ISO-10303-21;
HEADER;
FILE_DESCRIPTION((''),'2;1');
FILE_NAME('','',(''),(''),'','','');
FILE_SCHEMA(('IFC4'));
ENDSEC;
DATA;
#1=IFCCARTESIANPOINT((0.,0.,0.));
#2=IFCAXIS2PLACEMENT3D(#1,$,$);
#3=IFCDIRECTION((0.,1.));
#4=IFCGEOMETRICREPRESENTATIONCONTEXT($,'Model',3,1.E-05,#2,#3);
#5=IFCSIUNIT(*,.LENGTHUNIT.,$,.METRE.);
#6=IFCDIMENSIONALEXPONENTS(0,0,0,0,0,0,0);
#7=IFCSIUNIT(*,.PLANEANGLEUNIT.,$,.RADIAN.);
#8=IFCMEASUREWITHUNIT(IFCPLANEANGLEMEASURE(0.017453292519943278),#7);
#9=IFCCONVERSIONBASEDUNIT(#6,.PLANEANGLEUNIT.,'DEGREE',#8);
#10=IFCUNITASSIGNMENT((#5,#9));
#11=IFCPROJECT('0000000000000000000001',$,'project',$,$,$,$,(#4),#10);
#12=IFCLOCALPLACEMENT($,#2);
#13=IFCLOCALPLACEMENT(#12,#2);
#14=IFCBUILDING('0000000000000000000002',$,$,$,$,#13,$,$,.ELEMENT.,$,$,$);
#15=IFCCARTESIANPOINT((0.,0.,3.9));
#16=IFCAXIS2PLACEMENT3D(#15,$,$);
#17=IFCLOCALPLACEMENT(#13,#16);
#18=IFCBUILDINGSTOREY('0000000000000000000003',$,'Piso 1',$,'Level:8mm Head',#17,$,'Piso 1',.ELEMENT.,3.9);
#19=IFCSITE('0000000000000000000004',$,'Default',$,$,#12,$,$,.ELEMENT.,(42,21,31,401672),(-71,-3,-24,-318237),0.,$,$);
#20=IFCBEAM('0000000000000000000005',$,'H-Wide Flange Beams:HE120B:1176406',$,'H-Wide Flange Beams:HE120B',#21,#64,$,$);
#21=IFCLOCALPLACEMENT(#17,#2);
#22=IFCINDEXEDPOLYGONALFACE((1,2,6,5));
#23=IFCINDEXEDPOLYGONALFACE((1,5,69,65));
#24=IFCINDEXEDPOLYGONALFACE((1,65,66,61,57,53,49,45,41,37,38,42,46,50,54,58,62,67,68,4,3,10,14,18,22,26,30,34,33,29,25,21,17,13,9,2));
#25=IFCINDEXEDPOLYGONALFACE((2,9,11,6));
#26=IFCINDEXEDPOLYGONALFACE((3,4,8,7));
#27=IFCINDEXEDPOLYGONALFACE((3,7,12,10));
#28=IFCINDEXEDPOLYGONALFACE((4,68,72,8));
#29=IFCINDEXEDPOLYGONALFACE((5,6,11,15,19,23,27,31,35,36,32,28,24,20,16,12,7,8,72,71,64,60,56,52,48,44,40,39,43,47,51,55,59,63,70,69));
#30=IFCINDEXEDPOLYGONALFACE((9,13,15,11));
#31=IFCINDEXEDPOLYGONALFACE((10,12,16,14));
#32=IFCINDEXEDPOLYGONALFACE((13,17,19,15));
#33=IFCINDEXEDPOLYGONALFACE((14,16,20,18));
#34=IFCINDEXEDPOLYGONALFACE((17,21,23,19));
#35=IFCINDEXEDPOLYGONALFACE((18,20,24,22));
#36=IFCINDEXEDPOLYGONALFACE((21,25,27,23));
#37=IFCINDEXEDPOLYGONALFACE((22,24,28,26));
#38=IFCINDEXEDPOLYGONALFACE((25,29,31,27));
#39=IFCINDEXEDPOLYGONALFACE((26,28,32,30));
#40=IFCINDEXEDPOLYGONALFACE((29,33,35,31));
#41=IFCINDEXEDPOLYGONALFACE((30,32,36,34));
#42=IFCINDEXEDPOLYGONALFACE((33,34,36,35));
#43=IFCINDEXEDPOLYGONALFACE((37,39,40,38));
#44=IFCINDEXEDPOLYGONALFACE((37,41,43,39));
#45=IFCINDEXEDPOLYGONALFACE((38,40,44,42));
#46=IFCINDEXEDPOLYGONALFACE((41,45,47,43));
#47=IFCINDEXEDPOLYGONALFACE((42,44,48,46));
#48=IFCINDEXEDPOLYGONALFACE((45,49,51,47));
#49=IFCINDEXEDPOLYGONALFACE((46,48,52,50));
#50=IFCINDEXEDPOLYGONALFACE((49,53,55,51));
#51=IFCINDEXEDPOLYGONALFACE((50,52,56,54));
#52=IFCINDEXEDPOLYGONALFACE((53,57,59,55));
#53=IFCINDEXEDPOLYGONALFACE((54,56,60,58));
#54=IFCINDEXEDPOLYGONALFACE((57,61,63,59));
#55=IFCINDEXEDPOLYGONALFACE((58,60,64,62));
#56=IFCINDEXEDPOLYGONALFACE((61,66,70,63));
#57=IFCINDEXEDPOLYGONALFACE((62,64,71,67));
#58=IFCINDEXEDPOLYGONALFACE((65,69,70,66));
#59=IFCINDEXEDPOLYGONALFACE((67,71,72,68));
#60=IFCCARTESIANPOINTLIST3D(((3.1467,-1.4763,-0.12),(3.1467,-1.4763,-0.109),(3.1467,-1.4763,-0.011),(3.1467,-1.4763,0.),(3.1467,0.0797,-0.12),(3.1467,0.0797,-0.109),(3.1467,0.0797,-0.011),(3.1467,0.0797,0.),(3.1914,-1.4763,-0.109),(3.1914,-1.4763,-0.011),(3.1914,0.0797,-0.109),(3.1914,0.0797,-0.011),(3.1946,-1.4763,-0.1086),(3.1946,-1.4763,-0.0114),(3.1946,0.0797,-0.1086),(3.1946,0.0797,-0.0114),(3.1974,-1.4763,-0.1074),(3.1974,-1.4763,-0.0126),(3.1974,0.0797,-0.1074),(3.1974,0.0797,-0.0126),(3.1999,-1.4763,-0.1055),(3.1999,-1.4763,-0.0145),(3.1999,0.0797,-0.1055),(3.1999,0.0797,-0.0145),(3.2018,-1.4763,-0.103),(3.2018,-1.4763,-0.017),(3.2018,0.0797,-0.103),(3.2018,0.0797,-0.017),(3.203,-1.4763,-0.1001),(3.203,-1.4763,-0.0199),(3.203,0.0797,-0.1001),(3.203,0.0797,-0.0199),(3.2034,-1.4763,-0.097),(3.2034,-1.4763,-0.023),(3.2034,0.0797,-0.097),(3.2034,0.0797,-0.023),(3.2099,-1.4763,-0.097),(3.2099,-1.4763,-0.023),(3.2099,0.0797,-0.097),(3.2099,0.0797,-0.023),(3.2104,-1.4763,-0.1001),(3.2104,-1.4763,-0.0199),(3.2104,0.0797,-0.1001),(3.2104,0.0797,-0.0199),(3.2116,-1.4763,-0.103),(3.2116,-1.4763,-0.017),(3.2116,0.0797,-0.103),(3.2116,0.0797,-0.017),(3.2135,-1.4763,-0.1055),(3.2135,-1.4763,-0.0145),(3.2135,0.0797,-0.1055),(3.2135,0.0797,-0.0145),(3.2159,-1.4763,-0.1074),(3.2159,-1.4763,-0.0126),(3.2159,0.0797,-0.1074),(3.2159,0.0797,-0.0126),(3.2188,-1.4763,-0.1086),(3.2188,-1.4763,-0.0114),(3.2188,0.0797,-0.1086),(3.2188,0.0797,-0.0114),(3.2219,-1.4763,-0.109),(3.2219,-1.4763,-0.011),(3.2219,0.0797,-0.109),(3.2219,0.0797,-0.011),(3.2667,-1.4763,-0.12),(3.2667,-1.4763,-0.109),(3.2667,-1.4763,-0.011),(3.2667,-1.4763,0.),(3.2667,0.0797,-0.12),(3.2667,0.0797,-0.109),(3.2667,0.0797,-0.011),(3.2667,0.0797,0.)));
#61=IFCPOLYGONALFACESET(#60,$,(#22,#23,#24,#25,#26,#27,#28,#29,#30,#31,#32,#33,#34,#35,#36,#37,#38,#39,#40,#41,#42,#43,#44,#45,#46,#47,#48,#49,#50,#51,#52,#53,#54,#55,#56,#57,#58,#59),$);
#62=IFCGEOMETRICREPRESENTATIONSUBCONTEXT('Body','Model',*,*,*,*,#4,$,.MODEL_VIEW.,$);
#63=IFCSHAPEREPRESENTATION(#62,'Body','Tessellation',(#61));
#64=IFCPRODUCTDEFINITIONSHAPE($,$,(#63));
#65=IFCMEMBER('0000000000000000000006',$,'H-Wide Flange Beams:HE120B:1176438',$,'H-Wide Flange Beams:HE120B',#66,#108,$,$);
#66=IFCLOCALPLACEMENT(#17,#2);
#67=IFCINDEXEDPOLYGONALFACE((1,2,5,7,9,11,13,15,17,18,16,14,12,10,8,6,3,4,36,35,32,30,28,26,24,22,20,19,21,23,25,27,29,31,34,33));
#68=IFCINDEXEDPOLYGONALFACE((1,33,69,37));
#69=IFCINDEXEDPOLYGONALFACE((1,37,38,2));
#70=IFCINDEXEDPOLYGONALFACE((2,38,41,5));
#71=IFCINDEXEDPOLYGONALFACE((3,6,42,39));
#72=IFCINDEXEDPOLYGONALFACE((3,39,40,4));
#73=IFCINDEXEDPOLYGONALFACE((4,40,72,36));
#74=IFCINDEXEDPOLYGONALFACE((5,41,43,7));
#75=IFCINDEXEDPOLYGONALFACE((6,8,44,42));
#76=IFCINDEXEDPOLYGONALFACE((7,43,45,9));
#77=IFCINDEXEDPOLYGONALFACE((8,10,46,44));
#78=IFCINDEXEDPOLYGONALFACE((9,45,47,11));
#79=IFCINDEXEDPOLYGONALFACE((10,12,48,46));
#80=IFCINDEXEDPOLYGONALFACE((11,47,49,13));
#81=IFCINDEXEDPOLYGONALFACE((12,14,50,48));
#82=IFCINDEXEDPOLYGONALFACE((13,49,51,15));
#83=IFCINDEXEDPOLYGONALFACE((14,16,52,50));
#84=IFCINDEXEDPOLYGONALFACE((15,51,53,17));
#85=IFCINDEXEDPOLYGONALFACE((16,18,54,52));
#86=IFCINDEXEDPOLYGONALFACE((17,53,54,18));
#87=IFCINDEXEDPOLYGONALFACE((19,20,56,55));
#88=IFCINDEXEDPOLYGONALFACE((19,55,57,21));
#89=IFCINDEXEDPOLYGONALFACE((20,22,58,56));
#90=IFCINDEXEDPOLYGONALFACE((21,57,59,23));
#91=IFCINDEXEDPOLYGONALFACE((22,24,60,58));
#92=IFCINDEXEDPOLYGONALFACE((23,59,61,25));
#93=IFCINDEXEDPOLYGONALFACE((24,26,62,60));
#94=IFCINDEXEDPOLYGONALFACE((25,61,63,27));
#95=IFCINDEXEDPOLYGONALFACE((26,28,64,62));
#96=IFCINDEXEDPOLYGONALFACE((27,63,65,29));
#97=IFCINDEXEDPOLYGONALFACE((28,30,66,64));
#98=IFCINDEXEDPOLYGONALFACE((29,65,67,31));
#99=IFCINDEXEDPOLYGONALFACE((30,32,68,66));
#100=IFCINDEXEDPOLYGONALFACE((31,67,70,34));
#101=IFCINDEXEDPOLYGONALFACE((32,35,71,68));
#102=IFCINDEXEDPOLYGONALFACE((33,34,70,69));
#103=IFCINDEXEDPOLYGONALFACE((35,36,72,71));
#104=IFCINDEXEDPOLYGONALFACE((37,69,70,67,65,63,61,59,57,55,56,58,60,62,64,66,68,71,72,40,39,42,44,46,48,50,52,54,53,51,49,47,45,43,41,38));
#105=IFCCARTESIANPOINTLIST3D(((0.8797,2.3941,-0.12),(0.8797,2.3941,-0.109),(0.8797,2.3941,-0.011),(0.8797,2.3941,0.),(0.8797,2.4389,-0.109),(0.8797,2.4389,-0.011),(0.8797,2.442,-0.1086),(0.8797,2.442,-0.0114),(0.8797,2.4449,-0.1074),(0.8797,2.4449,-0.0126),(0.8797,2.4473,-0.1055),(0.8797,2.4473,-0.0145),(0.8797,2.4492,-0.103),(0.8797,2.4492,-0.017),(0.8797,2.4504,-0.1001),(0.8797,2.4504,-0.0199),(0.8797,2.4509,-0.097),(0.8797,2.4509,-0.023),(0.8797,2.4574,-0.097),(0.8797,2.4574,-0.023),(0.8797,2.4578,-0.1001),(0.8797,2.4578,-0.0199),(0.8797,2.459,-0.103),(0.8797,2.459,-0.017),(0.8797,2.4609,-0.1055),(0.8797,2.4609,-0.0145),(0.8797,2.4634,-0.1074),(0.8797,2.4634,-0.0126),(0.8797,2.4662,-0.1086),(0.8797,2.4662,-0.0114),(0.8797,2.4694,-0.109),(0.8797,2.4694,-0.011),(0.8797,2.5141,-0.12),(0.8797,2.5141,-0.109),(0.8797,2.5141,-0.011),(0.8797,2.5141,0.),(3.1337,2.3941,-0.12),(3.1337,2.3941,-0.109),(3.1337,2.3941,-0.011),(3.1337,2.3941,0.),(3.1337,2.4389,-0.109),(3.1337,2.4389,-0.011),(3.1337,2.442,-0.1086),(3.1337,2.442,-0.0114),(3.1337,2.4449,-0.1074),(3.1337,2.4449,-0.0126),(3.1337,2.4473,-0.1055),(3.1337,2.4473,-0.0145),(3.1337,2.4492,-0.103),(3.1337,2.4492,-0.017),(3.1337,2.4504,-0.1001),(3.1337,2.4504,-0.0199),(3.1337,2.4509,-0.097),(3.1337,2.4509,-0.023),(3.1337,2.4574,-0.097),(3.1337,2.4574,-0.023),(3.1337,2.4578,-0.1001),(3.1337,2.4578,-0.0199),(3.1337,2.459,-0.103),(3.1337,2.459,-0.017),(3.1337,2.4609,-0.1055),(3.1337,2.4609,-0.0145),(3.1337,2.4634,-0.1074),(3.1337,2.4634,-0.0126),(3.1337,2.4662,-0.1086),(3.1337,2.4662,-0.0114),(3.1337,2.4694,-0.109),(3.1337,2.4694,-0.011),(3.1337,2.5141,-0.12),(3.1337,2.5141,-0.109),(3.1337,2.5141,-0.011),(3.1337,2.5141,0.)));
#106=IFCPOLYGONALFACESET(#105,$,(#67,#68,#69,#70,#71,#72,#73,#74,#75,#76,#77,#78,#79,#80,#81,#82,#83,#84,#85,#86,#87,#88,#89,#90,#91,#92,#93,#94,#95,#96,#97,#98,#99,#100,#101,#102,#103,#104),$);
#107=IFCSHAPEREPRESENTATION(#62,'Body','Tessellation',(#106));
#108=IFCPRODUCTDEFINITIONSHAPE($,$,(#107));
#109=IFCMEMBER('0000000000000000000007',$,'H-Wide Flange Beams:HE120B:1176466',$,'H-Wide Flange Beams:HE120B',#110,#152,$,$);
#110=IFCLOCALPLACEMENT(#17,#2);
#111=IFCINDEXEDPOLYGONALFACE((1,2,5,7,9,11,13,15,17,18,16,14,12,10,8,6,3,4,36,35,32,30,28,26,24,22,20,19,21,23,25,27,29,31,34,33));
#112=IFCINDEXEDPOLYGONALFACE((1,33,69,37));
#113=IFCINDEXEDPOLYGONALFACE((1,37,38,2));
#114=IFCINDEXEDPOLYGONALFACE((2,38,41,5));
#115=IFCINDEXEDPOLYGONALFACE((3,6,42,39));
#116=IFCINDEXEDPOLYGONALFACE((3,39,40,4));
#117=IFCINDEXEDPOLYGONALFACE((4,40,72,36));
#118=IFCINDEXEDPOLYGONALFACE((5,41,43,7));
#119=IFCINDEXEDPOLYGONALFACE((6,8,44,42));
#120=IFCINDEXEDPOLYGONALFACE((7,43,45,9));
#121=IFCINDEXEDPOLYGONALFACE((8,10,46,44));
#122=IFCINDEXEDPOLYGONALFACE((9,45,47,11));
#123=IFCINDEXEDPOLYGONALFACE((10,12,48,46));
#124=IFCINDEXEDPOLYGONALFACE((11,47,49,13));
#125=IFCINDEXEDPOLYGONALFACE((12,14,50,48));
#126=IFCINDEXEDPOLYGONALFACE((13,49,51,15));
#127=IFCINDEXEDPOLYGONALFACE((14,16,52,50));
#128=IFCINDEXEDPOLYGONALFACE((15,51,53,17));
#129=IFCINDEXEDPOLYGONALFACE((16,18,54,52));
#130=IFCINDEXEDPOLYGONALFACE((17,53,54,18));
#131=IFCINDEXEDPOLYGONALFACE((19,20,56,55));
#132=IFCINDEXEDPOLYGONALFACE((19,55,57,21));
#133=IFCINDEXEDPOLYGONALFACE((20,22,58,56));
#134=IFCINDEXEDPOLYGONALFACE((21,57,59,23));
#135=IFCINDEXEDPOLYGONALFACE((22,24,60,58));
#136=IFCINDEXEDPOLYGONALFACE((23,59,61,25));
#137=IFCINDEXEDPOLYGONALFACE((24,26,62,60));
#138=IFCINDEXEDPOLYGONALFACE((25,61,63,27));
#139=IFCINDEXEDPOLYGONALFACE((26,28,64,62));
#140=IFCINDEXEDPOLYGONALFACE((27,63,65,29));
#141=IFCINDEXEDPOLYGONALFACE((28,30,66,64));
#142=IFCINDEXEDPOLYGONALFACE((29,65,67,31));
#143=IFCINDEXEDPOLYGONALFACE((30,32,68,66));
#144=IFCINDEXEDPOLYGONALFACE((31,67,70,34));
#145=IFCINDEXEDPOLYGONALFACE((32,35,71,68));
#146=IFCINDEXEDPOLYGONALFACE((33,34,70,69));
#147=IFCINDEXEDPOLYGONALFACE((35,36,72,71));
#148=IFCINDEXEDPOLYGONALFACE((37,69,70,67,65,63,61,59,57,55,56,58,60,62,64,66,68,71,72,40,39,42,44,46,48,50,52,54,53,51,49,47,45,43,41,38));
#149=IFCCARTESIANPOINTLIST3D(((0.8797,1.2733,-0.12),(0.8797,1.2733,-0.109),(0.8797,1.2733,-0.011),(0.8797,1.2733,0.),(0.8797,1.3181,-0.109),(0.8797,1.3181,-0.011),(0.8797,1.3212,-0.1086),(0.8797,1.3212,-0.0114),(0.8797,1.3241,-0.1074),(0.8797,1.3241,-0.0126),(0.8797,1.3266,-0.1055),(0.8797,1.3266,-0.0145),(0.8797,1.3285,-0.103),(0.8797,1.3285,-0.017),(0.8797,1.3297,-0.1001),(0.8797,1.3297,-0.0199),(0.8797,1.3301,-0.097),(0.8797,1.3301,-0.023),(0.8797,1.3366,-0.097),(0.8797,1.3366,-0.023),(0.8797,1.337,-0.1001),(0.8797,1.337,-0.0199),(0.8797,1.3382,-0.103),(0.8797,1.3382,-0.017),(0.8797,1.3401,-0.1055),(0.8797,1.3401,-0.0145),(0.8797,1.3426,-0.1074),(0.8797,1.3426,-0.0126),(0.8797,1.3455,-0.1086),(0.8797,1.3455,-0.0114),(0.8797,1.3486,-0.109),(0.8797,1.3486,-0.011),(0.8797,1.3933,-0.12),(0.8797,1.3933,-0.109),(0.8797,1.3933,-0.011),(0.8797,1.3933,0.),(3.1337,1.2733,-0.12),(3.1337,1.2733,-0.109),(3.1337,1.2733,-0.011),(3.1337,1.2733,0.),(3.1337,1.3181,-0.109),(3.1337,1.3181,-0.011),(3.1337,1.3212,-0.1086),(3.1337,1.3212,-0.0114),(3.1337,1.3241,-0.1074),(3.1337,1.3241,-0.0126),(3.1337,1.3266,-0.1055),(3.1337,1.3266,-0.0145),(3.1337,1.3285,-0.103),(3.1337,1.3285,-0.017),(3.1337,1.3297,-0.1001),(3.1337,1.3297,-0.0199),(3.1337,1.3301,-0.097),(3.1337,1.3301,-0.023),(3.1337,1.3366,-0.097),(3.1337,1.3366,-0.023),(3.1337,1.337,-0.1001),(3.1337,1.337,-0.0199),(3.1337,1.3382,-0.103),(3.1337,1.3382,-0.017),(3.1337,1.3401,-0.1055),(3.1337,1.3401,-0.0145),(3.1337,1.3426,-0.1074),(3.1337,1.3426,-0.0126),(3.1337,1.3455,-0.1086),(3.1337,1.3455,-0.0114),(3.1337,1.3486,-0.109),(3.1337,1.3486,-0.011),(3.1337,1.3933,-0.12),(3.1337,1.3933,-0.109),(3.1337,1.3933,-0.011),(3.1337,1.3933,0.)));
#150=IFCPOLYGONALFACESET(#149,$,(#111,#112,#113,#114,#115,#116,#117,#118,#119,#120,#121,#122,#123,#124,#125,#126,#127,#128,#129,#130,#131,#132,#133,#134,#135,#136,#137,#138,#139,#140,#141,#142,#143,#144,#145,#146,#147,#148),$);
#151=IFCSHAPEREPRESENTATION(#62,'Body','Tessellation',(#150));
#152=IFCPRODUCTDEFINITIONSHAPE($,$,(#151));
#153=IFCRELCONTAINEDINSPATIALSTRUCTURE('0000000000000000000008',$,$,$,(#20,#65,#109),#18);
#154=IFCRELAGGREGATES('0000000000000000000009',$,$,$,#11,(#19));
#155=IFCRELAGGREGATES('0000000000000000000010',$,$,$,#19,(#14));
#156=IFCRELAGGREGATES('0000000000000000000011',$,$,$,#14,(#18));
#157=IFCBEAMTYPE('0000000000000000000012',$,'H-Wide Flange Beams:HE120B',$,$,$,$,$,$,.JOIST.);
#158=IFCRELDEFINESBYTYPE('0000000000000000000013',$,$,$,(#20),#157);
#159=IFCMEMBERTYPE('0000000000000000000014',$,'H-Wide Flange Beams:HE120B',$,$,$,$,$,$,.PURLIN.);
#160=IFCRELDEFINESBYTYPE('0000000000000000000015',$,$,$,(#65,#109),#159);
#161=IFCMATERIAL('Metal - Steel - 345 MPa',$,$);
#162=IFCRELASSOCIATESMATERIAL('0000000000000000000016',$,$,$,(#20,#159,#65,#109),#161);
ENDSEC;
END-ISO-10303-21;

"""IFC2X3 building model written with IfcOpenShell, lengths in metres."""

from ifc_helpers import new_model, entity, si_unit, converted_unit, direction, frame, frame_2d, origin, place, context, subcontext, project, spatial, polyline, circle_curve, parameter, trimmed, segment, composite_curve, i_section, outline, extrude, source, transform, mapped, material, type_object, type_shapes, element, save


model = new_model("IFC2X3")

# Units and contexts
model_context = context("Model", 3, precision=1e-05, world=origin(), true_north=direction((0.0, 1.0)))
body_context = subcontext(model_context, "Body", "Model", "MODEL_VIEW")
ifc_project = project(units=[si_unit("LENGTHUNIT", "METRE"), converted_unit("PLANEANGLEUNIT", "DEGREE", entity("IfcPlaneAngleMeasure", 0.017453292519943278), si_unit("PLANEANGLEUNIT", "RADIAN"), dimensions=[0, 0, 0, 0, 0, 0, 0])], contexts=[model_context])

# Site, building, storey
site_placement = place(None, origin())
site = spatial("IfcSite", under=ifc_project, at=site_placement, Name="Default", CompositionType="ELEMENT", RefLatitude=(42, 21, 31, 401672), RefLongitude=(-71, -3, -24, -318237), RefElevation=0.0)
building_placement = place(site_placement, origin())
building = spatial("IfcBuilding", under=site, at=building_placement, CompositionType="ELEMENT")
storey_placement = place(building_placement, frame((0.0, 0.0, 3.9)))
storey = spatial("IfcBuildingStorey", under=building, at=storey_placement, Name="Piso 1", ObjectType="Level:8mm Head", LongName="Piso 1", CompositionType="ELEMENT", Elevation=3.9)

# Beam
ifc_material_1 = material(Name="Metal - Steel - 345 MPa")
beam_type_1 = type_object("IfcBeamType", Name="H-Wide Flange Beams:HE120B", PredefinedType="JOIST")
beam_1_placement = place(storey_placement, frame((3.2067, 0.1526, 0.0), z_axis=(0.0, 0.0, 1.0), x_axis=(0.0, -1.0, 0.0)))
element("IfcBeam", 1, at=beam_1_placement, inside=storey, type_object=beam_type_1, material=ifc_material_1, Name="H-Wide Flange Beams:HE120B:1176406", ObjectType="H-Wide Flange Beams:HE120B", context=body_context, shape_type="SweptSolid", body=[
    extrude(i_section(OverallWidth=0.12, OverallDepth=0.12, WebThickness=0.0065, FlangeThickness=0.011, FilletRadius=0.012, at=frame_2d((0.0, 0.0), x_axis=(0.0, 1.0))), frame((0.0729, 0.0, -0.06), z_axis=(1.0, 0.0, 0.0), x_axis=(0.0, 0.0, -1.0)), (0.0, 0.0, 1.0), 1.556),
])

# Members
member_type_1 = type_object("IfcMemberType", Name="H-Wide Flange Beams:HE120B", PredefinedType="PURLIN", material=ifc_material_1)
shared_shape_1 = source(origin(), body_context, "Body", "SweptSolid", [
    extrude(outline(composite_curve([segment(polyline([(-0.06, -0.049), (-0.06, -0.06)]), True, "CONTINUOUS"), segment(polyline([(-0.06, -0.06), (0.06, -0.06)]), True, "CONTINUOUS"), segment(polyline([(0.06, -0.06), (0.06, -0.049)]), True, "CONTINUOUS"), segment(polyline([(0.06, -0.049), (0.0152, -0.049)]), True, "CONTINUOUS"), segment(trimmed(circle_curve(frame_2d((0.0152, -0.037), x_axis=(0.0, -1.0)), 0.012), [parameter(270.0)], [parameter(0.0)], True, "PARAMETER"), False, "CONTINUOUS"), segment(polyline([(0.0032, -0.037), (0.0032, 0.037)]), True, "CONTINUOUS"), segment(trimmed(circle_curve(frame_2d((0.0152, 0.037), x_axis=(-1.0, 0.0)), 0.012), [parameter(270.0)], [parameter(360.0)], True, "PARAMETER"), False, "CONTINUOUS"), segment(polyline([(0.0152, 0.049), (0.06, 0.049)]), True, "CONTINUOUS"), segment(polyline([(0.06, 0.049), (0.06, 0.06)]), True, "CONTINUOUS"), segment(polyline([(0.06, 0.06), (-0.06, 0.06)]), True, "CONTINUOUS"), segment(polyline([(-0.06, 0.06), (-0.06, 0.049)]), True, "CONTINUOUS"), segment(polyline([(-0.06, 0.049), (-0.0153, 0.049)]), True, "CONTINUOUS"), segment(trimmed(circle_curve(frame_2d((-0.0153, 0.037), x_axis=(0.0, 1.0)), 0.012), [parameter(270.0)], [parameter(360.0)], True, "PARAMETER"), False, "CONTINUOUS"), segment(polyline([(-0.0033, 0.037), (-0.0033, -0.037)]), True, "CONTINUOUS"), segment(trimmed(circle_curve(frame_2d((-0.0153, -0.037), x_axis=(1.0, 0.0)), 0.012), [parameter(270.0)], [parameter(0.0)], True, "PARAMETER"), False, "CONTINUOUS"), segment(polyline([(-0.0153, -0.049), (-0.06, -0.049)]), True, "CONTINUOUS")], self_intersect=False)), frame((-1.127, 0.0, 0.0), z_axis=(-1.0, 0.0, 0.0), x_axis=(0.0, -1.0, 0.0)), (0.0, 0.0, -1.0), 2.254),
])
type_shapes(member_type_1, [shared_shape_1])
for number, where, name in (
    (2, (2.0067, 2.4541, -0.06), "H-Wide Flange Beams:HE120B:1176438"),
    (3, (2.0067, 1.3333, -0.06), "H-Wide Flange Beams:HE120B:1176466"),
):
    element("IfcMember", number, at=place(storey_placement, frame(where)), inside=storey, type_object=member_type_1, material=ifc_material_1, Name=name, ObjectType="H-Wide Flange Beams:HE120B", context=body_context, shape_type="MappedRepresentation", body=[
        mapped(shared_shape_1, transform((0.0, 0.0, 0.0), scale=1.0)),
    ])

save(model, "model.ifc")
